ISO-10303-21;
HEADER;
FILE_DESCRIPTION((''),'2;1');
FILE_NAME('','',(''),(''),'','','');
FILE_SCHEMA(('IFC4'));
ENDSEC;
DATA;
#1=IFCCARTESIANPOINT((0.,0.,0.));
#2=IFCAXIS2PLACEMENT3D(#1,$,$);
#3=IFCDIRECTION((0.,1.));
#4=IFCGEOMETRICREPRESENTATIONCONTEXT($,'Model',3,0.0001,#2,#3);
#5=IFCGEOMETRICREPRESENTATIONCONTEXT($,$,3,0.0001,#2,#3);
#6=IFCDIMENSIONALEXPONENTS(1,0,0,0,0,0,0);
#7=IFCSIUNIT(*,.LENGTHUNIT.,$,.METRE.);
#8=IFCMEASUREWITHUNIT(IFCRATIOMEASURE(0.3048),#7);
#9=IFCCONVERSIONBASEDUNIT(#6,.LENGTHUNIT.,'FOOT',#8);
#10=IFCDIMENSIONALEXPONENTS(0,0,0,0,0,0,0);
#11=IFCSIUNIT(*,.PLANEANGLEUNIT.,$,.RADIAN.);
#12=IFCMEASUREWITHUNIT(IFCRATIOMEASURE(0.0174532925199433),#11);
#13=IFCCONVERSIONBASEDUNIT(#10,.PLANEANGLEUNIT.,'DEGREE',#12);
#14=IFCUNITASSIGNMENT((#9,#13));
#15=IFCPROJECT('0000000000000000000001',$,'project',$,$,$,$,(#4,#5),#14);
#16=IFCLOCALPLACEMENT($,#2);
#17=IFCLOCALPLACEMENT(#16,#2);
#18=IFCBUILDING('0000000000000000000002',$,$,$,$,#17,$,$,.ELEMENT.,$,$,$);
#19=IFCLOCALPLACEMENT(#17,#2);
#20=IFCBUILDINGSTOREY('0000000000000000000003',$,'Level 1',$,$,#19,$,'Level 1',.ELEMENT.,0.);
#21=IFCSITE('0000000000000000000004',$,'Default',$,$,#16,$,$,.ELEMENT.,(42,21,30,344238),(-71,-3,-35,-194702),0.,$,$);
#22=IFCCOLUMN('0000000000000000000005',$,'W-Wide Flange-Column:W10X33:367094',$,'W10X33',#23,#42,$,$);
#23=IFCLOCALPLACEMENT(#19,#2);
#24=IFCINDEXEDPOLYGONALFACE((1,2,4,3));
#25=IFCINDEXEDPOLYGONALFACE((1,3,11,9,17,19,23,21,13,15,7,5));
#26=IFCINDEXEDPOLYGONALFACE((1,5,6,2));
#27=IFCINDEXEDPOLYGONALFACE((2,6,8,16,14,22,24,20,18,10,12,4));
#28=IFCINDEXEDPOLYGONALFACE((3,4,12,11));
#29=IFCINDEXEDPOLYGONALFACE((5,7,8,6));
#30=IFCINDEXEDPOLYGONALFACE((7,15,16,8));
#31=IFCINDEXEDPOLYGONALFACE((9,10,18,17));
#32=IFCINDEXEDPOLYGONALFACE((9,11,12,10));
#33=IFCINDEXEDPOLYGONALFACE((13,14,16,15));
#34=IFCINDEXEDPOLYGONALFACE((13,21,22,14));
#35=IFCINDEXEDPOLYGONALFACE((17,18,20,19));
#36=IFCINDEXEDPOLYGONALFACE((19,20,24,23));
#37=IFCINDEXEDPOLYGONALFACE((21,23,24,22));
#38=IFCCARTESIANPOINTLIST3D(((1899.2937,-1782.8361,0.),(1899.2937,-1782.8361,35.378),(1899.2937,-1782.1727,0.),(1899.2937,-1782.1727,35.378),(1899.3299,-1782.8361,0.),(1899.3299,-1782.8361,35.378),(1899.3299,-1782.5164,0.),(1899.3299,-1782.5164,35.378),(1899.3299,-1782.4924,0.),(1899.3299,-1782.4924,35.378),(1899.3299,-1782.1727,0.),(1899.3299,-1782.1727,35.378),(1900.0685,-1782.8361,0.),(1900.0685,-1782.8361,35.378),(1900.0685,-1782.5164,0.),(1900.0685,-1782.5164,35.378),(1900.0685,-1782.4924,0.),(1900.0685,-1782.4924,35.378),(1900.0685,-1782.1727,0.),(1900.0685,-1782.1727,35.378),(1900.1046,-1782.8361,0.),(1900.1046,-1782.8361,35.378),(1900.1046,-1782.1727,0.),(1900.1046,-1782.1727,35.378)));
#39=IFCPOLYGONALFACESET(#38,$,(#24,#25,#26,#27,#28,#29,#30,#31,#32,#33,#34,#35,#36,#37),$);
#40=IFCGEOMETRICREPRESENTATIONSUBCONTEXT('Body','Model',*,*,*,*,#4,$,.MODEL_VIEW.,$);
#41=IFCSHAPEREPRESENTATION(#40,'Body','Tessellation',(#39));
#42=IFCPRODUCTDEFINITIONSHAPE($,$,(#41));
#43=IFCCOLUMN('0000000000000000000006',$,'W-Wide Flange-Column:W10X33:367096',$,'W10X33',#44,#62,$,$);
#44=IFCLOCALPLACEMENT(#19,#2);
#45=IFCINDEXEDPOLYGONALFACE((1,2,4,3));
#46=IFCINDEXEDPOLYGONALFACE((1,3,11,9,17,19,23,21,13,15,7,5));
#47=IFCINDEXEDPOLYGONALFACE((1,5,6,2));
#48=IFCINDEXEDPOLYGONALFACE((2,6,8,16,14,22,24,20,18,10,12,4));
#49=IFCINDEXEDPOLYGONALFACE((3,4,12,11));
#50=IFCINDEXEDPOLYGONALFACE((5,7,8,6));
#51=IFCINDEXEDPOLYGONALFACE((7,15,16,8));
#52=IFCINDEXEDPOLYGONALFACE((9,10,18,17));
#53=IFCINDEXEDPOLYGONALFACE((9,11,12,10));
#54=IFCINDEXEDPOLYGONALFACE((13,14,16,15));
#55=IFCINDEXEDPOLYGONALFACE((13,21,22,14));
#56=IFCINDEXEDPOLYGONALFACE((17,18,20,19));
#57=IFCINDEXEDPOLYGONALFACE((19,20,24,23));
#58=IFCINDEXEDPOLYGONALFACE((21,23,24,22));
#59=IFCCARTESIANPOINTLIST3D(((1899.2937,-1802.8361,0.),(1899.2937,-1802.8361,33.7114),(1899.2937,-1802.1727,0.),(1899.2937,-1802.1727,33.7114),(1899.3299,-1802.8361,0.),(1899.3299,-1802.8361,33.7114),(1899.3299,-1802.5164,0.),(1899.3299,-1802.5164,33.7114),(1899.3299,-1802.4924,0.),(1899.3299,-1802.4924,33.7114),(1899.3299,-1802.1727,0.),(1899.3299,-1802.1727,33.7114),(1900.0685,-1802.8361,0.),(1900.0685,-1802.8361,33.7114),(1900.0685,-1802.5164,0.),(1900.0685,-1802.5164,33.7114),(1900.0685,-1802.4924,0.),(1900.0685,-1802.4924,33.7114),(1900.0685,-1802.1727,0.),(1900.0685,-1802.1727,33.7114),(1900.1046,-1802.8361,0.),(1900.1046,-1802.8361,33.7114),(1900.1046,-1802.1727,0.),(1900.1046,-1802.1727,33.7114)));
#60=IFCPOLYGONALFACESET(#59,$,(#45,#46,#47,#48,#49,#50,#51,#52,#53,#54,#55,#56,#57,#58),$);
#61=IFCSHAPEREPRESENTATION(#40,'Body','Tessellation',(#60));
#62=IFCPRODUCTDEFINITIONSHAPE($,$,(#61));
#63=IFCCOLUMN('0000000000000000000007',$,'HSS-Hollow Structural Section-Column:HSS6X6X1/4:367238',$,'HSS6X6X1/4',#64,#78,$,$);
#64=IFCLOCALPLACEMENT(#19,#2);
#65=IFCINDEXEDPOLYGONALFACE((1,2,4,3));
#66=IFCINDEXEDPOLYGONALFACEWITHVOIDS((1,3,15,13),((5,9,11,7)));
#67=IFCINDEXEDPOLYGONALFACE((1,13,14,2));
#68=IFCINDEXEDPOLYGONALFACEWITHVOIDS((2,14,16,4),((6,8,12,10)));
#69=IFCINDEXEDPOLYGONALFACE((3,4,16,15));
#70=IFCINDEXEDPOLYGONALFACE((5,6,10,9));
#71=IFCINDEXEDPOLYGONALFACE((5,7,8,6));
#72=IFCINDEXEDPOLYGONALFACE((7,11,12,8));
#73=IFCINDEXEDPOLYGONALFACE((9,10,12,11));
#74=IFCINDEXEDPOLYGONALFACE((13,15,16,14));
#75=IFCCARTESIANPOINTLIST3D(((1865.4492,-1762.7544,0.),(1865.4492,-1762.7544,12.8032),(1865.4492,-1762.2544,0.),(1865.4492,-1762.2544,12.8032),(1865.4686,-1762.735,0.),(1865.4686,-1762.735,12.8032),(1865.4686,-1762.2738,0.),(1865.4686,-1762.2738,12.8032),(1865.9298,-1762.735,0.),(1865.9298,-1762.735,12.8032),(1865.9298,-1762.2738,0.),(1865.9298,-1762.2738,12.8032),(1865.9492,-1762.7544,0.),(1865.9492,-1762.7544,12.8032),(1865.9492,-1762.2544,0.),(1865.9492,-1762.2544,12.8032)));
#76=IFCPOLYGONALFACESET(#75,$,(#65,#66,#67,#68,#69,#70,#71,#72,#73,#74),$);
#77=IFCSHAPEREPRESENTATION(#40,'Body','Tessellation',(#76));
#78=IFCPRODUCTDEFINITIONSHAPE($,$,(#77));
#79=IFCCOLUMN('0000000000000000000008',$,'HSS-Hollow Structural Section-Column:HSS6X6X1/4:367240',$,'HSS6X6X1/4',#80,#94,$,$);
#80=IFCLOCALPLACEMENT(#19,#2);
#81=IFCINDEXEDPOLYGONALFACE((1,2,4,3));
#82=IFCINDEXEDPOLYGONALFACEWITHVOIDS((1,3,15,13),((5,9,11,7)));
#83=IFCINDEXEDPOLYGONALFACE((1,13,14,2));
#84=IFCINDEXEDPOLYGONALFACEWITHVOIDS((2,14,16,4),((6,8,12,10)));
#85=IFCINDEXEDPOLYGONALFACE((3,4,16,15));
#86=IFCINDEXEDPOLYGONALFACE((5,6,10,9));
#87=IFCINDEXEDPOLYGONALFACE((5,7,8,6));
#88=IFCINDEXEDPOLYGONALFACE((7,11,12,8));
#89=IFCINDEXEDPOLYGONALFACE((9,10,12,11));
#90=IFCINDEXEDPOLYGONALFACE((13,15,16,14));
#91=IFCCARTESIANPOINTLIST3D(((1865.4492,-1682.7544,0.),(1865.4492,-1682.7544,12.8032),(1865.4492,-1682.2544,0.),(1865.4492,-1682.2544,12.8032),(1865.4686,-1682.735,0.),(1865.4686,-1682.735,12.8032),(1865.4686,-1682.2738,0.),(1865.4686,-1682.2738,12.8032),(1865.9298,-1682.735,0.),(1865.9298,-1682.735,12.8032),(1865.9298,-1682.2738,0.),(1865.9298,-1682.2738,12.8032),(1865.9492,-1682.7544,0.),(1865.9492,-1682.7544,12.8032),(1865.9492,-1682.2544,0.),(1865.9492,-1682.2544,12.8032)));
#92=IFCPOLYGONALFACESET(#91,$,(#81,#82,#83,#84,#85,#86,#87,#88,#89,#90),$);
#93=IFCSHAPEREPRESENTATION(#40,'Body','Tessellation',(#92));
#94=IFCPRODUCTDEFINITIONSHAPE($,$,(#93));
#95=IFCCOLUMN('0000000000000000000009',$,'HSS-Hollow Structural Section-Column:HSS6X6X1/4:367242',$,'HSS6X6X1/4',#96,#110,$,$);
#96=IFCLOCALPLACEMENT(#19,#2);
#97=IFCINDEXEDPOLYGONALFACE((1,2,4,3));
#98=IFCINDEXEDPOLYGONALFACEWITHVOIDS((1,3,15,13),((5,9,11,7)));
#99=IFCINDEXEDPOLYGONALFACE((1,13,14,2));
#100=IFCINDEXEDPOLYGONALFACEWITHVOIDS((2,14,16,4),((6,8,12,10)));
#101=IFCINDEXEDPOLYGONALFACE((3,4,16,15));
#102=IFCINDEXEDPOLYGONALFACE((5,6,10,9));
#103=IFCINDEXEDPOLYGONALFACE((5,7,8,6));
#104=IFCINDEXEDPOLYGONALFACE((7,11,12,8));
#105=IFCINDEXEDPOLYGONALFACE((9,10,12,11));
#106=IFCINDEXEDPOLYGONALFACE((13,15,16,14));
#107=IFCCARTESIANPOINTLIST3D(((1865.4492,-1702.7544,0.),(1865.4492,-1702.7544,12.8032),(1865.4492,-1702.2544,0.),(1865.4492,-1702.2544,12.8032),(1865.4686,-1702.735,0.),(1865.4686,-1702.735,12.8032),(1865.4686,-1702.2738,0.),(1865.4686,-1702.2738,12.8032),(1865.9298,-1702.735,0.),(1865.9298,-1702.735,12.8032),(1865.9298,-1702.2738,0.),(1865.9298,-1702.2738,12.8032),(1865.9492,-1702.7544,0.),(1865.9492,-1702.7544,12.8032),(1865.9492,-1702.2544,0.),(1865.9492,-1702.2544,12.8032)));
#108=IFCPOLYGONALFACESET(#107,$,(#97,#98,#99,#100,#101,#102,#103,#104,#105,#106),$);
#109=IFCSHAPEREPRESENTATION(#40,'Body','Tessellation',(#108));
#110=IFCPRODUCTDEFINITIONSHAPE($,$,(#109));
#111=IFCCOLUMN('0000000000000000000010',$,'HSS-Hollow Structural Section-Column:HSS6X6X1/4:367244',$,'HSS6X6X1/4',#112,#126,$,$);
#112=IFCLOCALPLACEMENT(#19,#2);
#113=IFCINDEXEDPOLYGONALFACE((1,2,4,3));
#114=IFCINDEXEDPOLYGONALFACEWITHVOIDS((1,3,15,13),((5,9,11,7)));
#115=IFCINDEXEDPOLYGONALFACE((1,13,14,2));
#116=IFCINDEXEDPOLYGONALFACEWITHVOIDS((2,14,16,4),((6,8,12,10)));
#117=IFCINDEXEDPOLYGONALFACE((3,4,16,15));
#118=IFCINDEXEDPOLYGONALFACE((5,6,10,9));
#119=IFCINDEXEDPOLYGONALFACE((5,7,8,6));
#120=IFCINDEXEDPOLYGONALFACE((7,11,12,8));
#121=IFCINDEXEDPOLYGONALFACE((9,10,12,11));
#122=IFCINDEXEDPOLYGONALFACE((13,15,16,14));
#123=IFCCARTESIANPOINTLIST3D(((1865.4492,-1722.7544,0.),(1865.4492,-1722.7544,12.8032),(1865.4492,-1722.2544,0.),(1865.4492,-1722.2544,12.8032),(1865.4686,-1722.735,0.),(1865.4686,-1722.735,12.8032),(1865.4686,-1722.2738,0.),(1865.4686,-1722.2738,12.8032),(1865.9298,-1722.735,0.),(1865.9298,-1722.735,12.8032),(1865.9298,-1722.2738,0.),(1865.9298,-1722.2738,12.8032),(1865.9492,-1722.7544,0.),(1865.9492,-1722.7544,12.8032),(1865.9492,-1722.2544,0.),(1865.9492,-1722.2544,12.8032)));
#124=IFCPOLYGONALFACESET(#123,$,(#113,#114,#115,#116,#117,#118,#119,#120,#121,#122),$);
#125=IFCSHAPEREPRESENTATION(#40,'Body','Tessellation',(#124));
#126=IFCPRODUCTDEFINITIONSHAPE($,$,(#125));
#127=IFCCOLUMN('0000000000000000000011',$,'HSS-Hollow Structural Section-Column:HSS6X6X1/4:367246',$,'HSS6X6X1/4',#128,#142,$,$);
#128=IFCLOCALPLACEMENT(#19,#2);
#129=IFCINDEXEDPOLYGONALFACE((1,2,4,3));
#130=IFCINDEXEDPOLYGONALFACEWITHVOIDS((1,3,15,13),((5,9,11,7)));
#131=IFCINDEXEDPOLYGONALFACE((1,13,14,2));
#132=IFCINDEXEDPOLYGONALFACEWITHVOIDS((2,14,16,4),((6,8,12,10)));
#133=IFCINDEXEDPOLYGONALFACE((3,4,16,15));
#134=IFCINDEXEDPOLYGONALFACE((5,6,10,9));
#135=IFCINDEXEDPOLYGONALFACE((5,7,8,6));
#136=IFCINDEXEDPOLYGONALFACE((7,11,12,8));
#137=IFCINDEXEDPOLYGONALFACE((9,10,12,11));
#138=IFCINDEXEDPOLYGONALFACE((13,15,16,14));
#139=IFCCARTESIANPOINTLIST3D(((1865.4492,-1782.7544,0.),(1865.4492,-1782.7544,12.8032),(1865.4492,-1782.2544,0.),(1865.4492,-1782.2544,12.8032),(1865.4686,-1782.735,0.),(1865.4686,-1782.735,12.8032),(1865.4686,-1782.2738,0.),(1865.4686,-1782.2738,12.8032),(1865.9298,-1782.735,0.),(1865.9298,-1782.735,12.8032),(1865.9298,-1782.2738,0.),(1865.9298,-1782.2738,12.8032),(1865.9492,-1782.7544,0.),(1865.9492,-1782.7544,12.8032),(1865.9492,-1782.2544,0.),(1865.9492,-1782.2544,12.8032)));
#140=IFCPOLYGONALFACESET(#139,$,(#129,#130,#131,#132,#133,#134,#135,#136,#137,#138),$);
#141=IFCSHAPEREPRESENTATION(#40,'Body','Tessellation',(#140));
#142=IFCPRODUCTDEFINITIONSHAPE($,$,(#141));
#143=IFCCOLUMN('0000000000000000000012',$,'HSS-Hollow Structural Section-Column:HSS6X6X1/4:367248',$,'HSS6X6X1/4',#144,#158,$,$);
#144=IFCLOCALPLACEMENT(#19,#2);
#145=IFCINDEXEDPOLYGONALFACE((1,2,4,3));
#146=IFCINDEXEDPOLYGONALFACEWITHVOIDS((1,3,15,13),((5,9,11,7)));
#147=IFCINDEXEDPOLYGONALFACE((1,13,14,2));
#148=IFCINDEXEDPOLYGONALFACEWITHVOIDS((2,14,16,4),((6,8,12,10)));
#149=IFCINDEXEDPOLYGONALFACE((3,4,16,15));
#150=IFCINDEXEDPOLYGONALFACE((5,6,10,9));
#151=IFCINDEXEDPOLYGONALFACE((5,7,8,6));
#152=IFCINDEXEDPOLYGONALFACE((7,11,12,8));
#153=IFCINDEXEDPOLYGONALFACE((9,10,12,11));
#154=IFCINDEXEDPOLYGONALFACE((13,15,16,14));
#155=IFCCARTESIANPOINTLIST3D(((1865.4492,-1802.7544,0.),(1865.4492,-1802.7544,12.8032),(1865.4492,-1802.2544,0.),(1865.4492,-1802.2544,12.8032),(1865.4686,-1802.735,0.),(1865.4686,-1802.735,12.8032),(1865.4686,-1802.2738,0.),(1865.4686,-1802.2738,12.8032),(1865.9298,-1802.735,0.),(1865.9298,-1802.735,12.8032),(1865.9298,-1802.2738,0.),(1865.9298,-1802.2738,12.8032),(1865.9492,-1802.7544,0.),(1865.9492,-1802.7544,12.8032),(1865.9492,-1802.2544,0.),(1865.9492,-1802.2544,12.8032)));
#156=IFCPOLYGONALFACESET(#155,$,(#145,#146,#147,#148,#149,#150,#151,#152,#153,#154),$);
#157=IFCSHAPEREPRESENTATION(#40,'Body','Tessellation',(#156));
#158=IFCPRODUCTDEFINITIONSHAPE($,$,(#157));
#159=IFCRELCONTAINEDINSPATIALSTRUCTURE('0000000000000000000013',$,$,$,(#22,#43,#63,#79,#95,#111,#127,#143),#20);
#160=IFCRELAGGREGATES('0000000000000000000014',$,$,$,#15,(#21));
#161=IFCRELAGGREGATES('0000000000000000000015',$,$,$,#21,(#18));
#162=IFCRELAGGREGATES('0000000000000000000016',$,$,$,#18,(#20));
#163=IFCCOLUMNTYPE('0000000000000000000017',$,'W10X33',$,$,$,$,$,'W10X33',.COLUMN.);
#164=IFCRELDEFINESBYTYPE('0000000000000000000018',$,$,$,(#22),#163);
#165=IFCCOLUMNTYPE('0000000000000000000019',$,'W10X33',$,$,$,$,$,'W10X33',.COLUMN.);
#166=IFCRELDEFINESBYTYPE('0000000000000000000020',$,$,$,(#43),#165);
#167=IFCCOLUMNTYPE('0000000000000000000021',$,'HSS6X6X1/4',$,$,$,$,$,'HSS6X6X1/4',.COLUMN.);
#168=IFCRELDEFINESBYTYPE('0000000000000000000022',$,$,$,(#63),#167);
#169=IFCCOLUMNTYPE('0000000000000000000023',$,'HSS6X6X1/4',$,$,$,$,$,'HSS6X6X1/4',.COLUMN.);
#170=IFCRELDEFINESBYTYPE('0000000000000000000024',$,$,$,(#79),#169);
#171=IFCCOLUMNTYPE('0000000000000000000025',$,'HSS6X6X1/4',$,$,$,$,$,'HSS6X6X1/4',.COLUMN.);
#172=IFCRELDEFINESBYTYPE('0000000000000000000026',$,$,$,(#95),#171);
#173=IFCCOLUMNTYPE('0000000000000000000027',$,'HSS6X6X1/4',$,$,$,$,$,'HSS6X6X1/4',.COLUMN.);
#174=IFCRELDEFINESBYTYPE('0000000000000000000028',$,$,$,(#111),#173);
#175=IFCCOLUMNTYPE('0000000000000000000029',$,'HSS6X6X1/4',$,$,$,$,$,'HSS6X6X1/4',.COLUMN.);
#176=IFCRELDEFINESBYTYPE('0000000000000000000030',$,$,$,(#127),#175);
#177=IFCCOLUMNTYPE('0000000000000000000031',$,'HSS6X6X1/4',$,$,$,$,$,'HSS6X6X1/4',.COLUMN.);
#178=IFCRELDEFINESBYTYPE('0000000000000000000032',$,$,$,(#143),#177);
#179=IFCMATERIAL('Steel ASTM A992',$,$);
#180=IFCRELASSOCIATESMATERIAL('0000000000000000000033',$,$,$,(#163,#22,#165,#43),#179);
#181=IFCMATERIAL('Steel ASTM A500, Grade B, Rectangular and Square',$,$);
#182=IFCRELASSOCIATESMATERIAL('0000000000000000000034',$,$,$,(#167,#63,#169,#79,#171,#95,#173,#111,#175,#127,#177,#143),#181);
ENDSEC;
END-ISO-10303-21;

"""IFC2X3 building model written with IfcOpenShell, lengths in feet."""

from ifc_helpers import new_model, entity, si_unit, converted_unit, direction, frame, frame_2d, origin, place, context, subcontext, project, spatial, polyline, i_section, outline, extrude, source, transform, mapped, material, type_object, type_shapes, element, save


model = new_model("IFC2X3")

# Units and contexts
model_context = context("Model", 3, precision=0.0001, world=origin(), true_north=direction((0.0, 1.0)))
context_of_model = context(None, 3, precision=0.0001, world=origin(), true_north=direction((0.0, 1.0)))
body_context = subcontext(model_context, "Body", "Model", "MODEL_VIEW")
ifc_project = project(units=[converted_unit("LENGTHUNIT", "FOOT", entity("IfcRatioMeasure", 0.3048), si_unit("LENGTHUNIT", "METRE"), dimensions=[1, 0, 0, 0, 0, 0, 0]), converted_unit("PLANEANGLEUNIT", "DEGREE", entity("IfcRatioMeasure", 0.0174532925199433), si_unit("PLANEANGLEUNIT", "RADIAN"), dimensions=[0, 0, 0, 0, 0, 0, 0])], contexts=[model_context, context_of_model])

# Site, building, storey
site_placement = place(None, origin())
site = spatial("IfcSite", under=ifc_project, at=site_placement, Name="Default", CompositionType="ELEMENT", RefLatitude=(42, 21, 30, 344238), RefLongitude=(-71, -3, -35, -194702), RefElevation=0.0)
building_placement = place(site_placement, origin())
building = spatial("IfcBuilding", under=site, at=building_placement, CompositionType="ELEMENT")
storey_placement = place(building_placement, origin())
storey = spatial("IfcBuildingStorey", under=building, at=storey_placement, Name="Level 1", LongName="Level 1", CompositionType="ELEMENT", Elevation=0.0)

# Columns
ifc_material_1 = material(Name="Steel ASTM A500, Grade B, Rectangular and Square")
ifc_material_2 = material(Name="Steel ASTM A992")
column_type_1 = type_object("IfcColumnType", Name="W10X33", ElementType="W10X33", PredefinedType="COLUMN", material=ifc_material_2)
shared_shape_1 = source(origin(), body_context, "Body", "SweptSolid", [
    extrude(i_section(OverallWidth=0.6634, OverallDepth=0.8109, WebThickness=0.0241, FlangeThickness=0.0361, at=frame_2d((0.0, 0.0), x_axis=(1.0, 0.0))), frame((0.4054, 0.3317, 0.0), z_axis=(0.0, 0.0, 1.0), x_axis=(0.0, 1.0, 0.0)), (0.0, 0.0, 1.0), 35.378),
])
type_shapes(column_type_1, [shared_shape_1])
column_1_placement = place(storey_placement, frame((1899.2937, -1782.8361, 0.0)))
element("IfcColumn", 1, at=column_1_placement, inside=storey, type_object=column_type_1, material=ifc_material_2, Name="W-Wide Flange-Column:W10X33:367094", ObjectType="W10X33", context=body_context, shape_type="MappedRepresentation", body=[
    mapped(shared_shape_1, transform((0.0, 0.0, 0.0), scale=1.0)),
])
column_type_2 = type_object("IfcColumnType", Name="W10X33", ElementType="W10X33", PredefinedType="COLUMN", material=ifc_material_2)
shared_shape_2 = source(origin(), body_context, "Body", "SweptSolid", [
    extrude(i_section(OverallWidth=0.6634, OverallDepth=0.8109, WebThickness=0.0241, FlangeThickness=0.0361, at=frame_2d((0.0, 0.0), x_axis=(1.0, 0.0))), frame((0.4054, 0.3317, 0.0), z_axis=(0.0, 0.0, 1.0), x_axis=(0.0, 1.0, 0.0)), (0.0, 0.0, 1.0), 33.7114),
])
type_shapes(column_type_2, [shared_shape_2])
column_2_placement = place(storey_placement, frame((1899.2937, -1802.8361, 0.0)))
element("IfcColumn", 2, at=column_2_placement, inside=storey, type_object=column_type_2, material=ifc_material_2, Name="W-Wide Flange-Column:W10X33:367096", ObjectType="W10X33", context=body_context, shape_type="MappedRepresentation", body=[
    mapped(shared_shape_2, transform((0.0, 0.0, 0.0), scale=1.0)),
])
column_type_3 = type_object("IfcColumnType", Name="HSS6X6X1/4", ElementType="HSS6X6X1/4", PredefinedType="COLUMN", material=ifc_material_1)
shared_shape_3 = source(origin(), body_context, "Body", "SweptSolid", [
    extrude(outline(polyline([(-0.25, -0.25), (0.25, -0.25), (0.25, 0.25), (-0.25, 0.25), (-0.25, -0.25)]), holes=[polyline([(-0.2306, -0.2306), (-0.2306, 0.2306), (0.2306, 0.2306), (0.2306, -0.2306), (-0.2306, -0.2306)])]), frame((0.25, 0.25, 0.0)), (0.0, 0.0, 1.0), 12.8032),
])
type_shapes(column_type_3, [shared_shape_3])
column_3_placement = place(storey_placement, frame((1865.4492, -1762.7544, 0.0)))
element("IfcColumn", 3, at=column_3_placement, inside=storey, type_object=column_type_3, material=ifc_material_1, Name="HSS-Hollow Structural Section-Column:HSS6X6X1/4:367238", ObjectType="HSS6X6X1/4", context=body_context, shape_type="MappedRepresentation", body=[
    mapped(shared_shape_3, transform((0.0, 0.0, 0.0), scale=1.0)),
])
column_type_4 = type_object("IfcColumnType", Name="HSS6X6X1/4", ElementType="HSS6X6X1/4", PredefinedType="COLUMN", material=ifc_material_1)
shared_shape_4 = source(origin(), body_context, "Body", "SweptSolid", [
    extrude(outline(polyline([(-0.25, -0.25), (0.25, -0.25), (0.25, 0.25), (-0.25, 0.25), (-0.25, -0.25)]), holes=[polyline([(-0.2306, -0.2306), (-0.2306, 0.2306), (0.2306, 0.2306), (0.2306, -0.2306), (-0.2306, -0.2306)])]), frame((0.25, 0.25, 0.0)), (0.0, 0.0, 1.0), 12.8032),
])
type_shapes(column_type_4, [shared_shape_4])
column_4_placement = place(storey_placement, frame((1865.4492, -1682.7544, 0.0)))
element("IfcColumn", 4, at=column_4_placement, inside=storey, type_object=column_type_4, material=ifc_material_1, Name="HSS-Hollow Structural Section-Column:HSS6X6X1/4:367240", ObjectType="HSS6X6X1/4", context=body_context, shape_type="MappedRepresentation", body=[
    mapped(shared_shape_4, transform((0.0, 0.0, 0.0), scale=1.0)),
])
column_type_5 = type_object("IfcColumnType", Name="HSS6X6X1/4", ElementType="HSS6X6X1/4", PredefinedType="COLUMN", material=ifc_material_1)
shared_shape_5 = source(origin(), body_context, "Body", "SweptSolid", [
    extrude(outline(polyline([(-0.25, -0.25), (0.25, -0.25), (0.25, 0.25), (-0.25, 0.25), (-0.25, -0.25)]), holes=[polyline([(-0.2306, -0.2306), (-0.2306, 0.2306), (0.2306, 0.2306), (0.2306, -0.2306), (-0.2306, -0.2306)])]), frame((0.25, 0.25, 0.0)), (0.0, 0.0, 1.0), 12.8032),
])
type_shapes(column_type_5, [shared_shape_5])
column_5_placement = place(storey_placement, frame((1865.4492, -1702.7544, 0.0)))
element("IfcColumn", 5, at=column_5_placement, inside=storey, type_object=column_type_5, material=ifc_material_1, Name="HSS-Hollow Structural Section-Column:HSS6X6X1/4:367242", ObjectType="HSS6X6X1/4", context=body_context, shape_type="MappedRepresentation", body=[
    mapped(shared_shape_5, transform((0.0, 0.0, 0.0), scale=1.0)),
])
column_type_6 = type_object("IfcColumnType", Name="HSS6X6X1/4", ElementType="HSS6X6X1/4", PredefinedType="COLUMN", material=ifc_material_1)
shared_shape_6 = source(origin(), body_context, "Body", "SweptSolid", [
    extrude(outline(polyline([(-0.25, -0.25), (0.25, -0.25), (0.25, 0.25), (-0.25, 0.25), (-0.25, -0.25)]), holes=[polyline([(-0.2306, -0.2306), (-0.2306, 0.2306), (0.2306, 0.2306), (0.2306, -0.2306), (-0.2306, -0.2306)])]), frame((0.25, 0.25, 0.0)), (0.0, 0.0, 1.0), 12.8032),
])
type_shapes(column_type_6, [shared_shape_6])
column_6_placement = place(storey_placement, frame((1865.4492, -1722.7544, 0.0)))
element("IfcColumn", 6, at=column_6_placement, inside=storey, type_object=column_type_6, material=ifc_material_1, Name="HSS-Hollow Structural Section-Column:HSS6X6X1/4:367244", ObjectType="HSS6X6X1/4", context=body_context, shape_type="MappedRepresentation", body=[
    mapped(shared_shape_6, transform((0.0, 0.0, 0.0), scale=1.0)),
])
column_type_7 = type_object("IfcColumnType", Name="HSS6X6X1/4", ElementType="HSS6X6X1/4", PredefinedType="COLUMN", material=ifc_material_1)
shared_shape_7 = source(origin(), body_context, "Body", "SweptSolid", [
    extrude(outline(polyline([(-0.25, -0.25), (0.25, -0.25), (0.25, 0.25), (-0.25, 0.25), (-0.25, -0.25)]), holes=[polyline([(-0.2306, -0.2306), (-0.2306, 0.2306), (0.2306, 0.2306), (0.2306, -0.2306), (-0.2306, -0.2306)])]), frame((0.25, 0.25, 0.0)), (0.0, 0.0, 1.0), 12.8032),
])
type_shapes(column_type_7, [shared_shape_7])
column_7_placement = place(storey_placement, frame((1865.4492, -1782.7544, 0.0)))
element("IfcColumn", 7, at=column_7_placement, inside=storey, type_object=column_type_7, material=ifc_material_1, Name="HSS-Hollow Structural Section-Column:HSS6X6X1/4:367246", ObjectType="HSS6X6X1/4", context=body_context, shape_type="MappedRepresentation", body=[
    mapped(shared_shape_7, transform((0.0, 0.0, 0.0), scale=1.0)),
])
column_type_8 = type_object("IfcColumnType", Name="HSS6X6X1/4", ElementType="HSS6X6X1/4", PredefinedType="COLUMN", material=ifc_material_1)
shared_shape_8 = source(origin(), body_context, "Body", "SweptSolid", [
    extrude(outline(polyline([(-0.25, -0.25), (0.25, -0.25), (0.25, 0.25), (-0.25, 0.25), (-0.25, -0.25)]), holes=[polyline([(-0.2306, -0.2306), (-0.2306, 0.2306), (0.2306, 0.2306), (0.2306, -0.2306), (-0.2306, -0.2306)])]), frame((0.25, 0.25, 0.0)), (0.0, 0.0, 1.0), 12.8032),
])
type_shapes(column_type_8, [shared_shape_8])
column_8_placement = place(storey_placement, frame((1865.4492, -1802.7544, 0.0)))
element("IfcColumn", 8, at=column_8_placement, inside=storey, type_object=column_type_8, material=ifc_material_1, Name="HSS-Hollow Structural Section-Column:HSS6X6X1/4:367248", ObjectType="HSS6X6X1/4", context=body_context, shape_type="MappedRepresentation", body=[
    mapped(shared_shape_8, transform((0.0, 0.0, 0.0), scale=1.0)),
])

save(model, "model.ifc")
